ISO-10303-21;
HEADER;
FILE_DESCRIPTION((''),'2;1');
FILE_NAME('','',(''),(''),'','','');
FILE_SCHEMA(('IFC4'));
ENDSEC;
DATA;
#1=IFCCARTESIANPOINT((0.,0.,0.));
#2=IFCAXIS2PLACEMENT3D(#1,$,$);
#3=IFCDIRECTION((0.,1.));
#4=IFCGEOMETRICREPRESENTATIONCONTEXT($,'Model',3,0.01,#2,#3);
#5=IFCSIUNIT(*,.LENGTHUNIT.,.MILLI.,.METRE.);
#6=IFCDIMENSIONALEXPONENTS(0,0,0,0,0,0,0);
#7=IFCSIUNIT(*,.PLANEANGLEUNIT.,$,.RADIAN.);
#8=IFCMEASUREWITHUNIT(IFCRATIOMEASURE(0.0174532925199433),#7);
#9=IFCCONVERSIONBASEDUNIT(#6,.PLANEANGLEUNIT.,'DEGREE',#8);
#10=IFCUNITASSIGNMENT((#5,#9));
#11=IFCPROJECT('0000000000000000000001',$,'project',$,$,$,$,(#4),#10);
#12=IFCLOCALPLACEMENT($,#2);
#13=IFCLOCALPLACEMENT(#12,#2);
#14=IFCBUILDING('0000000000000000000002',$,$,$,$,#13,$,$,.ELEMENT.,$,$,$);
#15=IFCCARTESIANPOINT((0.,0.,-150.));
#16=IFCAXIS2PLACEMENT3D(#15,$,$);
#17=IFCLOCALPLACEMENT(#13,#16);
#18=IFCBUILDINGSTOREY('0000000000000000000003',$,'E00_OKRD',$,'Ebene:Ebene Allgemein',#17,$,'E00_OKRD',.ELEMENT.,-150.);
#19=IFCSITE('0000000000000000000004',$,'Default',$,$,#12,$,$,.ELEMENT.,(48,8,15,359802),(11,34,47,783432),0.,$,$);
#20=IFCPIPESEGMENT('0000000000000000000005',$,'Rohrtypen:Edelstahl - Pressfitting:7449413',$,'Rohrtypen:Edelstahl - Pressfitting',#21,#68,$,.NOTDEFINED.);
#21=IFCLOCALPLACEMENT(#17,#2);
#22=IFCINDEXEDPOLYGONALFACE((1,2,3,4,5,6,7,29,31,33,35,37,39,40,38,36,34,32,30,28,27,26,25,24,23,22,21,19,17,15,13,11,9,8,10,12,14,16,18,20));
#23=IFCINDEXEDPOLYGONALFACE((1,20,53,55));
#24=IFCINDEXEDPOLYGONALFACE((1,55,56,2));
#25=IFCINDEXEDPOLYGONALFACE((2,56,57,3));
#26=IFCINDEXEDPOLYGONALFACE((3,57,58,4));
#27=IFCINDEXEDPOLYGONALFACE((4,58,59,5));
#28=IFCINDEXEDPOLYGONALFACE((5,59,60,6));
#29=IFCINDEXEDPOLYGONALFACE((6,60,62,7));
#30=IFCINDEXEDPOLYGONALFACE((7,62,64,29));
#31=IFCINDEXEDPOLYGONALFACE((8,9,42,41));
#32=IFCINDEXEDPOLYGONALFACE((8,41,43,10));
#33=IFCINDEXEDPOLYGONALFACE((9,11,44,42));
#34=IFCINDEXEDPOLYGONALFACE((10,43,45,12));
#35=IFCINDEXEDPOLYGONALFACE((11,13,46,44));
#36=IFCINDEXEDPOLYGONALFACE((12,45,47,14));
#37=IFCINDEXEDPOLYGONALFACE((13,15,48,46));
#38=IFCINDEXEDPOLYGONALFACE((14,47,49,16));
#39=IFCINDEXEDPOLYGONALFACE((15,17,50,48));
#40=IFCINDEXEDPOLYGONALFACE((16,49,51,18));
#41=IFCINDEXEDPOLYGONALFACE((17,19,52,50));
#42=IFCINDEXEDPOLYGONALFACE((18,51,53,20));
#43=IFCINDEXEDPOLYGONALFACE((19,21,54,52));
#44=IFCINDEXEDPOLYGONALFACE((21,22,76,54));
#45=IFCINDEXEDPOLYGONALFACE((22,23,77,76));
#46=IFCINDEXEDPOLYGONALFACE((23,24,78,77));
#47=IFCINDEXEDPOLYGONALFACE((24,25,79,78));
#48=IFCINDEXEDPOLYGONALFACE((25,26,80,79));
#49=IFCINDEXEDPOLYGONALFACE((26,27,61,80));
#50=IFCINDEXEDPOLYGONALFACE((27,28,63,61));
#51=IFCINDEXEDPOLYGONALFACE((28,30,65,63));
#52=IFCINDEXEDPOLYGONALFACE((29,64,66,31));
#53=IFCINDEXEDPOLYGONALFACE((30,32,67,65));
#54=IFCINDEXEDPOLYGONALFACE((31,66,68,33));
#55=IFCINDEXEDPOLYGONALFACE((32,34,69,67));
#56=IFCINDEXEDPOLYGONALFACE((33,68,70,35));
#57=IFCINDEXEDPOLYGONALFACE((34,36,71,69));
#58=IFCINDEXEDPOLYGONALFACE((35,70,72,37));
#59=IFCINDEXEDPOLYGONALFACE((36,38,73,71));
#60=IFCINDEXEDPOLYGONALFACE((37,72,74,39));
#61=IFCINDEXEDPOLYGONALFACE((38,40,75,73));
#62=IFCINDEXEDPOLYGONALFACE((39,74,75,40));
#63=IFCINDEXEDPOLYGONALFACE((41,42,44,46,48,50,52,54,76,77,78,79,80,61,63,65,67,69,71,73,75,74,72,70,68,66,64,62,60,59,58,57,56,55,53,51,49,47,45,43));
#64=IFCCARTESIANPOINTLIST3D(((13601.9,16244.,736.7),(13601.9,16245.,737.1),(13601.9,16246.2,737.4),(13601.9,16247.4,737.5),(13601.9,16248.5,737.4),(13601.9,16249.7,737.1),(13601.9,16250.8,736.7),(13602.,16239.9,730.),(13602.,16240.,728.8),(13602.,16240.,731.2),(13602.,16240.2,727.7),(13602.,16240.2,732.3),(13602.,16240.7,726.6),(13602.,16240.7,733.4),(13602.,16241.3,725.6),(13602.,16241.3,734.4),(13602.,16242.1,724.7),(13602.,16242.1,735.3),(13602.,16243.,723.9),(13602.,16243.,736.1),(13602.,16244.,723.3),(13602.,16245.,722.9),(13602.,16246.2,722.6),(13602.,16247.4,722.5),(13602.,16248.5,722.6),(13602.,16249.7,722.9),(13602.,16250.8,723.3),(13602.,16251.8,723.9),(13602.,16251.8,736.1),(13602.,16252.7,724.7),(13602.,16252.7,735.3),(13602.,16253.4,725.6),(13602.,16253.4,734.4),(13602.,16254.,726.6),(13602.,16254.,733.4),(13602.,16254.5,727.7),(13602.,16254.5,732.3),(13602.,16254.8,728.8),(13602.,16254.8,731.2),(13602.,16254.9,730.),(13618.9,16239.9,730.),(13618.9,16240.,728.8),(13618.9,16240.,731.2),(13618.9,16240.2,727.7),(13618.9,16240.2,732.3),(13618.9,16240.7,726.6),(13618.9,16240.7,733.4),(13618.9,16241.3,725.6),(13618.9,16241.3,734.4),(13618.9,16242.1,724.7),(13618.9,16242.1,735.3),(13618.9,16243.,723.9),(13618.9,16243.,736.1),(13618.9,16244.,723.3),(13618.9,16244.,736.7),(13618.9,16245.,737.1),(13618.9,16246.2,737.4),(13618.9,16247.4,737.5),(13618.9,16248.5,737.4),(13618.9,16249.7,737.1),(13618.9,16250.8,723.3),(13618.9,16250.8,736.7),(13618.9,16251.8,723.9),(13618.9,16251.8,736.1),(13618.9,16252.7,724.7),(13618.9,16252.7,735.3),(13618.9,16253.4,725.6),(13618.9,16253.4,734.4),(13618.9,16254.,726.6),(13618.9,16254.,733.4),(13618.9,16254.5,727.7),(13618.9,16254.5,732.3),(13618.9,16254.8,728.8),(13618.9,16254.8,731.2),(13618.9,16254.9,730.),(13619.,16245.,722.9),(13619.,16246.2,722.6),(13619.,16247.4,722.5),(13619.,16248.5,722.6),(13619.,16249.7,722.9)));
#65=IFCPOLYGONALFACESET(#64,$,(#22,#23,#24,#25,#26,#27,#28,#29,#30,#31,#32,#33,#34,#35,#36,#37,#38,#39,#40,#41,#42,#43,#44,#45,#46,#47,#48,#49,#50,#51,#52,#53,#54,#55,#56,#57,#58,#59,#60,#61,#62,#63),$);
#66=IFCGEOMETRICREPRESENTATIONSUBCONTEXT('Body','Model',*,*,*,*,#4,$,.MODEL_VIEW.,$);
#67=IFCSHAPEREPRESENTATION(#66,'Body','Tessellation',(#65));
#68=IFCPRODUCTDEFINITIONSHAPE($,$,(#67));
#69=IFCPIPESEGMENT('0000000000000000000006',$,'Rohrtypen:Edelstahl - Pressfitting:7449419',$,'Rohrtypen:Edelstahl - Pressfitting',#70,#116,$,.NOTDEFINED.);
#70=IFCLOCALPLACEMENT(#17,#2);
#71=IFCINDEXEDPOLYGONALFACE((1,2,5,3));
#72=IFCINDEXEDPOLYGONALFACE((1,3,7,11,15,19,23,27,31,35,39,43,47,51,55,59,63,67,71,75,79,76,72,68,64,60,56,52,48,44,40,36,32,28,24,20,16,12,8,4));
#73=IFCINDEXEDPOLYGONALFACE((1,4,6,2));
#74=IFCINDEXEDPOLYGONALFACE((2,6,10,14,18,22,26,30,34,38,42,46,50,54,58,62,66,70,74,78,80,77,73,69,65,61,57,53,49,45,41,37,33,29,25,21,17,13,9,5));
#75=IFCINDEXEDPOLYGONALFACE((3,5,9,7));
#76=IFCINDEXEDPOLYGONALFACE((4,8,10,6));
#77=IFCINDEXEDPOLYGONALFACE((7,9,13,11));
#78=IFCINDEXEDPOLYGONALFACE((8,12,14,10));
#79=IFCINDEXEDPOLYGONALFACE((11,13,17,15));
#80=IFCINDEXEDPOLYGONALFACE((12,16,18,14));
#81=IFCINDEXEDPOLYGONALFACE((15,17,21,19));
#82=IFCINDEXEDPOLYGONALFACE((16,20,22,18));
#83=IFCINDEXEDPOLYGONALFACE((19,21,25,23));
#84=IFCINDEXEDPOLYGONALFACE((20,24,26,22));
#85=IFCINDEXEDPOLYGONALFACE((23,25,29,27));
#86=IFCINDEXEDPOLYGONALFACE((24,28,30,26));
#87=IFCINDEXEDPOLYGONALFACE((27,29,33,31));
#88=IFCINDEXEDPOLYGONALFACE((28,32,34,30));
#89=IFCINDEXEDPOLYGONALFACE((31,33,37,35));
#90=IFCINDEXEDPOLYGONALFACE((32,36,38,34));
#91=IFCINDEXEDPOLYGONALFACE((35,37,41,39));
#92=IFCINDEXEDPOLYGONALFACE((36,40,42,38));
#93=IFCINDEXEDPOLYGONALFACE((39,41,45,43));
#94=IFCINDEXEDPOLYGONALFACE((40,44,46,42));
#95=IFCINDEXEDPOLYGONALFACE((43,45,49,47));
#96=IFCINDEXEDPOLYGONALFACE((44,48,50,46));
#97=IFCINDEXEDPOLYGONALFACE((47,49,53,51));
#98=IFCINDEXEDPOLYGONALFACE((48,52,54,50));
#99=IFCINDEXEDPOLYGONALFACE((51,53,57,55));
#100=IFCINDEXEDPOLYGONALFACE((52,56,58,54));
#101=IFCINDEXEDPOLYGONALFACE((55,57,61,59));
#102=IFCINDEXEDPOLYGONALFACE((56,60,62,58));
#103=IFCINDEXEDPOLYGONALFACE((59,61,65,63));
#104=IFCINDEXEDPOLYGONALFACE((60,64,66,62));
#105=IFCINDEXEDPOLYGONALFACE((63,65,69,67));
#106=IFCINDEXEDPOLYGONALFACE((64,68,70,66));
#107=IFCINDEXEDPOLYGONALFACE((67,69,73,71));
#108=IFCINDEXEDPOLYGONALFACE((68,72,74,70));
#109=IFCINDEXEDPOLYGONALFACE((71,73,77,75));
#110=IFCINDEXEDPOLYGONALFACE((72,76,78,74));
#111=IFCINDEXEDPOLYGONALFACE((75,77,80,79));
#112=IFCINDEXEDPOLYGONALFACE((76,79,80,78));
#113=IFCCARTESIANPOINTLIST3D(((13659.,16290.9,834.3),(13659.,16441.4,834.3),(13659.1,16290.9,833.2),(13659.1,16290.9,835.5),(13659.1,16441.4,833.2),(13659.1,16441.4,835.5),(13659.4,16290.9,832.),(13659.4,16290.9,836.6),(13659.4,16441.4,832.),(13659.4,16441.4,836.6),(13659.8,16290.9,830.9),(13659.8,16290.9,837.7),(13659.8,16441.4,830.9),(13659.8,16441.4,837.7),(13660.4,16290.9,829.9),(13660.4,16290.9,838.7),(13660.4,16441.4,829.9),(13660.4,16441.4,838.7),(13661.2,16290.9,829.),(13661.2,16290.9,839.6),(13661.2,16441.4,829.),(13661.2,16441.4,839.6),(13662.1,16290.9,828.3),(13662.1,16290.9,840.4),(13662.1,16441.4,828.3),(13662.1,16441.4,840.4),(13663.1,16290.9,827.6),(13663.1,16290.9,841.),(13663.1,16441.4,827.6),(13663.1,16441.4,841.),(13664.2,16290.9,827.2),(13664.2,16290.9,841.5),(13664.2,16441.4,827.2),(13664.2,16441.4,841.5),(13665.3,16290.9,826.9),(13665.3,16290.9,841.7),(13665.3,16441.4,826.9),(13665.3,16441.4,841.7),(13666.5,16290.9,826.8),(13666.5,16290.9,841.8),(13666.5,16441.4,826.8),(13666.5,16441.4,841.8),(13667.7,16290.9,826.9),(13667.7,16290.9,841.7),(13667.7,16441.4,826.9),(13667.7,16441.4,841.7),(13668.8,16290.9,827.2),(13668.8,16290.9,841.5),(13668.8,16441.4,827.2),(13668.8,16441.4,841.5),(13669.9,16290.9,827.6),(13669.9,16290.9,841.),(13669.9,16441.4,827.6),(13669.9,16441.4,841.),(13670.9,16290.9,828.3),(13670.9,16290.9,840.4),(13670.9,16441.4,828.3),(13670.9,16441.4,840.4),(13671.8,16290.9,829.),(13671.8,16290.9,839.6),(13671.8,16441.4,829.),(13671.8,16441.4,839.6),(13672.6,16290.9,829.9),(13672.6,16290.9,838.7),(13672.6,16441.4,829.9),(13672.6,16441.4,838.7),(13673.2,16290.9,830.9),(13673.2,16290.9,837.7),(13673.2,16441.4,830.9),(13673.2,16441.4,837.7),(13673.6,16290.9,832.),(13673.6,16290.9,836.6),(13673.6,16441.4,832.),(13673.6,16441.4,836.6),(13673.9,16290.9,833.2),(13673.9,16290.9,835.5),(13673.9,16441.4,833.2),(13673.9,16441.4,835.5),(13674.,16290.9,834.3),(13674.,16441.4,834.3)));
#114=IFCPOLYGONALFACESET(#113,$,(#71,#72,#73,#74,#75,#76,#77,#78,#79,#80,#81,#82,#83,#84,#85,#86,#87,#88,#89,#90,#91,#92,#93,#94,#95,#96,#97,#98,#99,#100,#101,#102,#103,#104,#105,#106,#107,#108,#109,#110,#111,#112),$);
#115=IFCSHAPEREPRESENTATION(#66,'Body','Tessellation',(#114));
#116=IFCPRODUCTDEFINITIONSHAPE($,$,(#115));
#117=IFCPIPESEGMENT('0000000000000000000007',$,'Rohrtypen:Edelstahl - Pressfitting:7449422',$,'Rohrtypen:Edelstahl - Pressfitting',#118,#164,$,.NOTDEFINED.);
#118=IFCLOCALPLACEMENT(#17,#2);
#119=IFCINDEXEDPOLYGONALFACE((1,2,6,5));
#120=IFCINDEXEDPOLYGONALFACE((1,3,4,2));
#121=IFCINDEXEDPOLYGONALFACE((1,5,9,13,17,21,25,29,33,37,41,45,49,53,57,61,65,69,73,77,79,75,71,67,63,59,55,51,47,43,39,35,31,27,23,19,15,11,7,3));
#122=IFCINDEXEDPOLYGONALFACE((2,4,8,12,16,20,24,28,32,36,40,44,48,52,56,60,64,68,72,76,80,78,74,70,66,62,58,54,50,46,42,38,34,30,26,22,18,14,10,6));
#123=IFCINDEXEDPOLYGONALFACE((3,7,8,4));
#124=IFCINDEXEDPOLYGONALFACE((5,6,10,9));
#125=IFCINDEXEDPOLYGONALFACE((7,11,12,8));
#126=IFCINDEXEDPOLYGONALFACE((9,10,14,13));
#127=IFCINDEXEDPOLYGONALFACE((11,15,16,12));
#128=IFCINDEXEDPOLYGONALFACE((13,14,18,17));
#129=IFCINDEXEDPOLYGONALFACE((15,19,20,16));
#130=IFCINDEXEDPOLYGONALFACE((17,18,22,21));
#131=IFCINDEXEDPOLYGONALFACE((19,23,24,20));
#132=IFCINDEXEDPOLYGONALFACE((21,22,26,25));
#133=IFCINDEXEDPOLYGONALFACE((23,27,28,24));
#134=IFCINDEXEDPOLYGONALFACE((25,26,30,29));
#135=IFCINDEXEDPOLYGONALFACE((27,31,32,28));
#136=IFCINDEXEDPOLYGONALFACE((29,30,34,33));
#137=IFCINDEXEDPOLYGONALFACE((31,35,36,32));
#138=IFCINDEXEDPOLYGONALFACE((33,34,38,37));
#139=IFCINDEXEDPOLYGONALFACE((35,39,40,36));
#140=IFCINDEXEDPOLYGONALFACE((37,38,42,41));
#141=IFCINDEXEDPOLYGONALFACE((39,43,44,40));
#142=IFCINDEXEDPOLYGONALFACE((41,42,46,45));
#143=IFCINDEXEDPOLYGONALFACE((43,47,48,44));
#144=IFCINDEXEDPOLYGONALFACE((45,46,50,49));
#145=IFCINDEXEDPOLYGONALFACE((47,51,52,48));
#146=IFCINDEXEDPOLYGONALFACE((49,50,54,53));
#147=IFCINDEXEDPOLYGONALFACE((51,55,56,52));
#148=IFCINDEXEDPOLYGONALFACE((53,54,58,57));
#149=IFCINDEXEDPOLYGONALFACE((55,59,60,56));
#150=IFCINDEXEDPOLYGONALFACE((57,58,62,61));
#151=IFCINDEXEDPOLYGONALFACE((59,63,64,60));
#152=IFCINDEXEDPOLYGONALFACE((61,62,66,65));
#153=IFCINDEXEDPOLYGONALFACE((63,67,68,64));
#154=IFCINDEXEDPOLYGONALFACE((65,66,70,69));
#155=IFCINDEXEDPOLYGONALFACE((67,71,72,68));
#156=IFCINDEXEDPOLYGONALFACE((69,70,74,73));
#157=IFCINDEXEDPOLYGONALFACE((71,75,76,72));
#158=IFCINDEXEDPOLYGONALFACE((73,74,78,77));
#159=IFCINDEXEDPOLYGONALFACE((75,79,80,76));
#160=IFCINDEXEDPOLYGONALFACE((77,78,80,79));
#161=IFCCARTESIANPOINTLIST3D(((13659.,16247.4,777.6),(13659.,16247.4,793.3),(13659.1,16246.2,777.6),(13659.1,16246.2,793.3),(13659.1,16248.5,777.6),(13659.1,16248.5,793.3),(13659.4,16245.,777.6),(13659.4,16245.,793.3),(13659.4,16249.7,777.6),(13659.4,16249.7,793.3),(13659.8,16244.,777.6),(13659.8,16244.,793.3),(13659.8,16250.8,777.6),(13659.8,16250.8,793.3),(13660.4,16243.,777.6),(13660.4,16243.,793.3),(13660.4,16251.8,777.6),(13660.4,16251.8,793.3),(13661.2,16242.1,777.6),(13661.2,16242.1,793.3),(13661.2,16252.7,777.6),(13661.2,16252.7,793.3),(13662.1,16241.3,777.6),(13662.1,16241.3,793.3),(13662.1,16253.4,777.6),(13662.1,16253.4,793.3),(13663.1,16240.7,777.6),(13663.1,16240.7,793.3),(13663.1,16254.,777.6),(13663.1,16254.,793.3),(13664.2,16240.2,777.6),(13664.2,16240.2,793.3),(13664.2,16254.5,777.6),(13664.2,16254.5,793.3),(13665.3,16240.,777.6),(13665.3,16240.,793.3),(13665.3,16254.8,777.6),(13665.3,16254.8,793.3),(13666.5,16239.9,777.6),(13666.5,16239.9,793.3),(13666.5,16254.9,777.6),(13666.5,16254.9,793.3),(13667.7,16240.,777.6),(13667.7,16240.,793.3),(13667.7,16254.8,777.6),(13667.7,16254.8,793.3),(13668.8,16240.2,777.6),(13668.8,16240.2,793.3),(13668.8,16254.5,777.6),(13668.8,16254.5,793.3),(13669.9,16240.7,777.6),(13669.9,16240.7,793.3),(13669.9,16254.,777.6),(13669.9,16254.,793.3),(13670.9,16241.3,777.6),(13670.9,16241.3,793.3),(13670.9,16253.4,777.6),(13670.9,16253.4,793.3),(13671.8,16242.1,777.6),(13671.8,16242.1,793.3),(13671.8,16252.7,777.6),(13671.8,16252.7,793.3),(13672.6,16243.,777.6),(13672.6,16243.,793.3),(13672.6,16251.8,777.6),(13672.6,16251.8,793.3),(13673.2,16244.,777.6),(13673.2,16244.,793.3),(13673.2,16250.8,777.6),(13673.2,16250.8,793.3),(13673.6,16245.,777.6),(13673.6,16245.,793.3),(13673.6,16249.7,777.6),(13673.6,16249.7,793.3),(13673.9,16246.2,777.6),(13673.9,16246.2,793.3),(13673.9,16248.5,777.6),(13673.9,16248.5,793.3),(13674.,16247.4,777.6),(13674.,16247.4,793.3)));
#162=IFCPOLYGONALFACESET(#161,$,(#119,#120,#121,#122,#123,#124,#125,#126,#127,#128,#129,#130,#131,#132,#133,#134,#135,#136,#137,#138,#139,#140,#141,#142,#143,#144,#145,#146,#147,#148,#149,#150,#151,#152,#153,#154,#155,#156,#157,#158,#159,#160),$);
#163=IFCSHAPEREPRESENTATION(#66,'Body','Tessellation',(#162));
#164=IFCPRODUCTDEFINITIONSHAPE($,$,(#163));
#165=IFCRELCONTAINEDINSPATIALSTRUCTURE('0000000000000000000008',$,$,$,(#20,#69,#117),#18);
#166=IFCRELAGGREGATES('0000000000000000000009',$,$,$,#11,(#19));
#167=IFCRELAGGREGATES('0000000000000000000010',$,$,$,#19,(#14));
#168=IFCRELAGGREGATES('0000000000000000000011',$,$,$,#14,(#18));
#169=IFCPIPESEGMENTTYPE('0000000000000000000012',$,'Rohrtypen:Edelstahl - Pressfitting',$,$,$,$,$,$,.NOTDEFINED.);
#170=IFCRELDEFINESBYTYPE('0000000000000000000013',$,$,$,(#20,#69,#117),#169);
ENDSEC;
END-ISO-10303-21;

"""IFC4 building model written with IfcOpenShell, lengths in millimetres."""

from ifc_helpers import new_model, entity, si_unit, converted_unit, direction, frame, origin, place, context, subcontext, project, spatial, indexed_curve, outline, extrude, type_object, element, save


model = new_model("IFC4")

# Units and contexts
model_context = context("Model", 3, precision=0.01, world=origin(), true_north=direction((0.0, 1.0)))
body_context = subcontext(model_context, "Body", "Model", "MODEL_VIEW")
ifc_project = project(units=[si_unit("LENGTHUNIT", "METRE", prefix="MILLI"), converted_unit("PLANEANGLEUNIT", "DEGREE", entity("IfcRatioMeasure", 0.0174532925199433), si_unit("PLANEANGLEUNIT", "RADIAN"), dimensions=[0, 0, 0, 0, 0, 0, 0])], contexts=[model_context])

# Site, building, storey
site_placement = place(None, origin())
site = spatial("IfcSite", under=ifc_project, at=site_placement, Name="Default", CompositionType="ELEMENT", RefLatitude=(48, 8, 15, 359802), RefLongitude=(11, 34, 47, 783432), RefElevation=0.0)
building_placement = place(site_placement, origin())
building = spatial("IfcBuilding", under=site, at=building_placement, CompositionType="ELEMENT")
storey_placement = place(building_placement, frame((0.0, 0.0, -150.0)))
storey = spatial("IfcBuildingStorey", under=building, at=storey_placement, Name="E00_OKRD", ObjectType="Ebene:Ebene Allgemein", LongName="E00_OKRD", CompositionType="ELEMENT", Elevation=-150.0)

# Pipe segments
pipe_segment_type_1 = type_object("IfcPipeSegmentType", Name="Rohrtypen:Edelstahl - Pressfitting", PredefinedType="NOTDEFINED")
pipe_segment_1_placement = place(storey_placement, origin())
element("IfcPipeSegment", 1, at=pipe_segment_1_placement, inside=storey, type_object=pipe_segment_type_1, Name="Rohrtypen:Edelstahl - Pressfitting:7449413", ObjectType="Rohrtypen:Edelstahl - Pressfitting", PredefinedType="NOTDEFINED", context=body_context, shape_type="SweptSolid", body=[
    extrude(outline(indexed_curve([(7.5, 0.0), (7.4, 1.2), (7.1, 2.3), (6.7, 3.4), (6.1, 4.4), (5.3, 5.3), (4.4, 6.1), (3.4, 6.7), (2.3, 7.1), (1.2, 7.4), (0.0, 7.5), (-1.2, 7.4), (-2.3, 7.1), (-3.4, 6.7), (-4.4, 6.1), (-5.3, 5.3), (-6.1, 4.4), (-6.7, 3.4), (-7.1, 2.3), (-7.4, 1.2), (-7.5, 0.0), (-7.4, -1.2), (-7.1, -2.3), (-6.7, -3.4), (-6.1, -4.4), (-5.3, -5.3), (-4.4, -6.1), (-3.4, -6.7), (-2.3, -7.1), (-1.2, -7.4), (0.0, -7.5), (1.2, -7.4), (2.3, -7.1), (3.4, -6.7), (4.4, -6.1), (5.3, -5.3), (6.1, -4.4), (6.7, -3.4), (7.1, -2.3), (7.4, -1.2), (7.5, 0.0)], self_intersect=False)), frame((13602.0, 16247.4, 730.0), z_axis=(1.0, 0.0, 0.00053), x_axis=(0.0, -1.0, 0.0)), (0.0, 0.0, 1.0), 17.0),
])
pipe_segment_2_placement = place(storey_placement, origin())
element("IfcPipeSegment", 2, at=pipe_segment_2_placement, inside=storey, type_object=pipe_segment_type_1, Name="Rohrtypen:Edelstahl - Pressfitting:7449419", ObjectType="Rohrtypen:Edelstahl - Pressfitting", PredefinedType="NOTDEFINED", context=body_context, shape_type="SweptSolid", body=[
    extrude(outline(indexed_curve([(7.5, 0.0), (7.4, 1.2), (7.1, 2.3), (6.7, 3.4), (6.1, 4.4), (5.3, 5.3), (4.4, 6.1), (3.4, 6.7), (2.3, 7.1), (1.2, 7.4), (0.0, 7.5), (-1.2, 7.4), (-2.3, 7.1), (-3.4, 6.7), (-4.4, 6.1), (-5.3, 5.3), (-6.1, 4.4), (-6.7, 3.4), (-7.1, 2.3), (-7.4, 1.2), (-7.5, 0.0), (-7.4, -1.2), (-7.1, -2.3), (-6.7, -3.4), (-6.1, -4.4), (-5.3, -5.3), (-4.4, -6.1), (-3.4, -6.7), (-2.3, -7.1), (-1.2, -7.4), (0.0, -7.5), (1.2, -7.4), (2.3, -7.1), (3.4, -6.7), (4.4, -6.1), (5.3, -5.3), (6.1, -4.4), (6.7, -3.4), (7.1, -2.3), (7.4, -1.2), (7.5, 0.0)], self_intersect=False)), frame((13666.5, 16290.9, 834.3), z_axis=(0.0, 1.0, 0.0), x_axis=(1.0, 0.0, 0.0)), (0.0, 0.0, 1.0), 150.5),
])
pipe_segment_3_placement = place(storey_placement, origin())
element("IfcPipeSegment", 3, at=pipe_segment_3_placement, inside=storey, type_object=pipe_segment_type_1, Name="Rohrtypen:Edelstahl - Pressfitting:7449422", ObjectType="Rohrtypen:Edelstahl - Pressfitting", PredefinedType="NOTDEFINED", context=body_context, shape_type="SweptSolid", body=[
    extrude(outline(indexed_curve([(7.5, 0.0), (7.4, 1.2), (7.1, 2.3), (6.7, 3.4), (6.1, 4.4), (5.3, 5.3), (4.4, 6.1), (3.4, 6.7), (2.3, 7.1), (1.2, 7.4), (0.0, 7.5), (-1.2, 7.4), (-2.3, 7.1), (-3.4, 6.7), (-4.4, 6.1), (-5.3, 5.3), (-6.1, 4.4), (-6.7, 3.4), (-7.1, 2.3), (-7.4, 1.2), (-7.5, 0.0), (-7.4, -1.2), (-7.1, -2.3), (-6.7, -3.4), (-6.1, -4.4), (-5.3, -5.3), (-4.4, -6.1), (-3.4, -6.7), (-2.3, -7.1), (-1.2, -7.4), (0.0, -7.5), (1.2, -7.4), (2.3, -7.1), (3.4, -6.7), (4.4, -6.1), (5.3, -5.3), (6.1, -4.4), (6.7, -3.4), (7.1, -2.3), (7.4, -1.2), (7.5, 0.0)], self_intersect=False)), frame((13666.5, 16247.4, 777.6), z_axis=(0.0, 0.0, 1.0), x_axis=(-1.0, 0.0, 0.0)), (0.0, 0.0, 1.0), 15.7),
])

save(model, "model.ifc")
